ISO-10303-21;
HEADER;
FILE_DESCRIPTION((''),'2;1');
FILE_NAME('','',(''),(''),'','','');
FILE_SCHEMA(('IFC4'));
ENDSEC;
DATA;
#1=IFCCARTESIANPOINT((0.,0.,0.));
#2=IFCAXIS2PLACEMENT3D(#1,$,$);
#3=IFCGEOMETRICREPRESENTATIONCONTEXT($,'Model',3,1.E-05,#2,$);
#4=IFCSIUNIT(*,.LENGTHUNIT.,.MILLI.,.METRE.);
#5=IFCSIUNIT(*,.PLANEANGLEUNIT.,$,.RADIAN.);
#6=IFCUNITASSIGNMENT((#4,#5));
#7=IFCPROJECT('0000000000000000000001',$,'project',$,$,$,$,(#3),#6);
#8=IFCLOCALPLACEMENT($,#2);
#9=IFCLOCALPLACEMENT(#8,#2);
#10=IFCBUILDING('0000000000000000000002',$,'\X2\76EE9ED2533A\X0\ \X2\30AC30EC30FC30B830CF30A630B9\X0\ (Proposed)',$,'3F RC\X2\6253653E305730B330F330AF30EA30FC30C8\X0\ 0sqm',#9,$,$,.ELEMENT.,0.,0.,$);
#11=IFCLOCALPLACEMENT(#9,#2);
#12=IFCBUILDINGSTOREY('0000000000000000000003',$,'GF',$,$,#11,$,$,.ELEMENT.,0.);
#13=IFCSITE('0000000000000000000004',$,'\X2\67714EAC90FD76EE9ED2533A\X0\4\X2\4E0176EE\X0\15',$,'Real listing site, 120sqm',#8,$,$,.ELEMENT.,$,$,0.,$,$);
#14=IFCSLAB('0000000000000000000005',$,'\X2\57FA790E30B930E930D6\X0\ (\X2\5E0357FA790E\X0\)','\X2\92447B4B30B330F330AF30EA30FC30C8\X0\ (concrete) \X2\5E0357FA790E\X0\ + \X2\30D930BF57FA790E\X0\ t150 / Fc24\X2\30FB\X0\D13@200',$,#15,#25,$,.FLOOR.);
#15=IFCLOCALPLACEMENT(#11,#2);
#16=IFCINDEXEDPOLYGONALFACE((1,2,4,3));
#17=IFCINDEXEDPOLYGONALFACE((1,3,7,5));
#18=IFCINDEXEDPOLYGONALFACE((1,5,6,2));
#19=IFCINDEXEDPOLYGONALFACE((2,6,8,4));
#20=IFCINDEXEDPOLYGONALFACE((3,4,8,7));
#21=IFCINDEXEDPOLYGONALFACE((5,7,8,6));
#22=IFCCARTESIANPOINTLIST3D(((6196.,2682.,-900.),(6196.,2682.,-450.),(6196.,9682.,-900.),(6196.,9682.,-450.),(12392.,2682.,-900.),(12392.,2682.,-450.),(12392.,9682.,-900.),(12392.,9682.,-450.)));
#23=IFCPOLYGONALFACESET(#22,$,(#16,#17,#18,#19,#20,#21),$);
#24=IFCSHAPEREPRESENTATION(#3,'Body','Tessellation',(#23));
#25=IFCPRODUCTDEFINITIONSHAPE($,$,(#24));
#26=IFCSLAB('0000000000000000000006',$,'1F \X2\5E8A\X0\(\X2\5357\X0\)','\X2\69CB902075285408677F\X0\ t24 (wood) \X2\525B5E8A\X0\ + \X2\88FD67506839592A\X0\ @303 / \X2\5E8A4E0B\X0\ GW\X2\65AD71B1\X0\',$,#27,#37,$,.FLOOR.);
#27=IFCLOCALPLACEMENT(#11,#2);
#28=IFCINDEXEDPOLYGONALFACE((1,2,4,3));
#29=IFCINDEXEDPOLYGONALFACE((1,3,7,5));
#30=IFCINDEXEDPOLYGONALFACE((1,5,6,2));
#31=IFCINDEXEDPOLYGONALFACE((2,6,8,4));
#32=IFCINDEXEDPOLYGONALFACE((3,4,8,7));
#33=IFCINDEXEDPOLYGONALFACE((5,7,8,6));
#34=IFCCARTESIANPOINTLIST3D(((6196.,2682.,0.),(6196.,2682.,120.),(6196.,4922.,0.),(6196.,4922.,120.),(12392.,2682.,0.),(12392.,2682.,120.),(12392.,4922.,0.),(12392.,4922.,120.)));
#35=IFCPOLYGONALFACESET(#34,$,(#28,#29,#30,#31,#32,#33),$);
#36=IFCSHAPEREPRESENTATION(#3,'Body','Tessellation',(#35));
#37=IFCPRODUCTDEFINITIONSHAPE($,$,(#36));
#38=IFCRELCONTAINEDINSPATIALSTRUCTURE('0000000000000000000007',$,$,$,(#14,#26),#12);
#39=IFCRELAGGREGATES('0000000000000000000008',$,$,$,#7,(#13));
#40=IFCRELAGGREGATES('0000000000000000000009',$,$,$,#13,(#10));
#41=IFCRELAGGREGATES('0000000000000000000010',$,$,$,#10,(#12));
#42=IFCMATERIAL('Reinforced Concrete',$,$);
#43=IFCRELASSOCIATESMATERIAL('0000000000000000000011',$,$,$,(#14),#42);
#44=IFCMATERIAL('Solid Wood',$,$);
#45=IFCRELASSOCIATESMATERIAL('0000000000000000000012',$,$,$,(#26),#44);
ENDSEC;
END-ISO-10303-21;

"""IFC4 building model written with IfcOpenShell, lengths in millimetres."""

from ifc_helpers import new_model, si_unit, frame, frame_2d, origin, place, context, project, spatial, rectangle, extrude, material, element, save


model = new_model("IFC4")

# Units and contexts
model_context = context("Model", 3, precision=1e-05, world=origin())
ifc_project = project(units=[si_unit("LENGTHUNIT", "METRE", prefix="MILLI"), si_unit("PLANEANGLEUNIT", "RADIAN")], contexts=[model_context])

# Site, building, storey
site_placement = place(None, origin())
site = spatial("IfcSite", under=ifc_project, at=site_placement, Name="東京都目黒区4丁目15", ObjectType="Real listing site, 120sqm", CompositionType="ELEMENT", RefElevation=0.0)
building_placement = place(site_placement, origin())
building = spatial("IfcBuilding", under=site, at=building_placement, Name="目黒区 ガレージハウス (Proposed)", ObjectType="3F RC打放しコンクリート 0sqm", CompositionType="ELEMENT", ElevationOfRefHeight=0.0, ElevationOfTerrain=0.0)
storey_placement = place(building_placement, origin())
storey = spatial("IfcBuildingStorey", under=building, at=storey_placement, Name="GF", CompositionType="ELEMENT", Elevation=0.0)

# Slabs
ifc_material_1 = material(Name="Reinforced Concrete")
slab_1_placement = place(storey_placement, frame((3098.0, 1341.0, -450.0)))
element("IfcSlab", 1, at=slab_1_placement, inside=storey, material=ifc_material_1, Name="基礎スラブ (布基礎)", Description="鉄筋コンクリート (concrete) 布基礎 + ベタ基礎 t150 / Fc24・D13@200", PredefinedType="FLOOR", context=model_context, shape_type="SweptSolid", body=[
    extrude(rectangle(XDim=6196.0, YDim=7000.0, at=frame_2d((3098.0, 3500.0))), frame((3098.0, 1341.0, -450.0)), (0.0, 0.0, 1.0), 450.0),
])
ifc_material_2 = material(Name="Solid Wood")
slab_2_placement = place(storey_placement, frame((3098.0, 1341.0, 0.0)))
element("IfcSlab", 2, at=slab_2_placement, inside=storey, material=ifc_material_2, Name="1F 床(南)", Description="構造用合板 t24 (wood) 剛床 + 製材根太 @303 / 床下 GW断熱", PredefinedType="FLOOR", context=model_context, shape_type="SweptSolid", body=[
    extrude(rectangle(XDim=6196.0, YDim=2240.0, at=frame_2d((3098.0, 1120.0))), frame((3098.0, 1341.0, 0.0)), (0.0, 0.0, 1.0), 120.0),
])

save(model, "model.ifc")
